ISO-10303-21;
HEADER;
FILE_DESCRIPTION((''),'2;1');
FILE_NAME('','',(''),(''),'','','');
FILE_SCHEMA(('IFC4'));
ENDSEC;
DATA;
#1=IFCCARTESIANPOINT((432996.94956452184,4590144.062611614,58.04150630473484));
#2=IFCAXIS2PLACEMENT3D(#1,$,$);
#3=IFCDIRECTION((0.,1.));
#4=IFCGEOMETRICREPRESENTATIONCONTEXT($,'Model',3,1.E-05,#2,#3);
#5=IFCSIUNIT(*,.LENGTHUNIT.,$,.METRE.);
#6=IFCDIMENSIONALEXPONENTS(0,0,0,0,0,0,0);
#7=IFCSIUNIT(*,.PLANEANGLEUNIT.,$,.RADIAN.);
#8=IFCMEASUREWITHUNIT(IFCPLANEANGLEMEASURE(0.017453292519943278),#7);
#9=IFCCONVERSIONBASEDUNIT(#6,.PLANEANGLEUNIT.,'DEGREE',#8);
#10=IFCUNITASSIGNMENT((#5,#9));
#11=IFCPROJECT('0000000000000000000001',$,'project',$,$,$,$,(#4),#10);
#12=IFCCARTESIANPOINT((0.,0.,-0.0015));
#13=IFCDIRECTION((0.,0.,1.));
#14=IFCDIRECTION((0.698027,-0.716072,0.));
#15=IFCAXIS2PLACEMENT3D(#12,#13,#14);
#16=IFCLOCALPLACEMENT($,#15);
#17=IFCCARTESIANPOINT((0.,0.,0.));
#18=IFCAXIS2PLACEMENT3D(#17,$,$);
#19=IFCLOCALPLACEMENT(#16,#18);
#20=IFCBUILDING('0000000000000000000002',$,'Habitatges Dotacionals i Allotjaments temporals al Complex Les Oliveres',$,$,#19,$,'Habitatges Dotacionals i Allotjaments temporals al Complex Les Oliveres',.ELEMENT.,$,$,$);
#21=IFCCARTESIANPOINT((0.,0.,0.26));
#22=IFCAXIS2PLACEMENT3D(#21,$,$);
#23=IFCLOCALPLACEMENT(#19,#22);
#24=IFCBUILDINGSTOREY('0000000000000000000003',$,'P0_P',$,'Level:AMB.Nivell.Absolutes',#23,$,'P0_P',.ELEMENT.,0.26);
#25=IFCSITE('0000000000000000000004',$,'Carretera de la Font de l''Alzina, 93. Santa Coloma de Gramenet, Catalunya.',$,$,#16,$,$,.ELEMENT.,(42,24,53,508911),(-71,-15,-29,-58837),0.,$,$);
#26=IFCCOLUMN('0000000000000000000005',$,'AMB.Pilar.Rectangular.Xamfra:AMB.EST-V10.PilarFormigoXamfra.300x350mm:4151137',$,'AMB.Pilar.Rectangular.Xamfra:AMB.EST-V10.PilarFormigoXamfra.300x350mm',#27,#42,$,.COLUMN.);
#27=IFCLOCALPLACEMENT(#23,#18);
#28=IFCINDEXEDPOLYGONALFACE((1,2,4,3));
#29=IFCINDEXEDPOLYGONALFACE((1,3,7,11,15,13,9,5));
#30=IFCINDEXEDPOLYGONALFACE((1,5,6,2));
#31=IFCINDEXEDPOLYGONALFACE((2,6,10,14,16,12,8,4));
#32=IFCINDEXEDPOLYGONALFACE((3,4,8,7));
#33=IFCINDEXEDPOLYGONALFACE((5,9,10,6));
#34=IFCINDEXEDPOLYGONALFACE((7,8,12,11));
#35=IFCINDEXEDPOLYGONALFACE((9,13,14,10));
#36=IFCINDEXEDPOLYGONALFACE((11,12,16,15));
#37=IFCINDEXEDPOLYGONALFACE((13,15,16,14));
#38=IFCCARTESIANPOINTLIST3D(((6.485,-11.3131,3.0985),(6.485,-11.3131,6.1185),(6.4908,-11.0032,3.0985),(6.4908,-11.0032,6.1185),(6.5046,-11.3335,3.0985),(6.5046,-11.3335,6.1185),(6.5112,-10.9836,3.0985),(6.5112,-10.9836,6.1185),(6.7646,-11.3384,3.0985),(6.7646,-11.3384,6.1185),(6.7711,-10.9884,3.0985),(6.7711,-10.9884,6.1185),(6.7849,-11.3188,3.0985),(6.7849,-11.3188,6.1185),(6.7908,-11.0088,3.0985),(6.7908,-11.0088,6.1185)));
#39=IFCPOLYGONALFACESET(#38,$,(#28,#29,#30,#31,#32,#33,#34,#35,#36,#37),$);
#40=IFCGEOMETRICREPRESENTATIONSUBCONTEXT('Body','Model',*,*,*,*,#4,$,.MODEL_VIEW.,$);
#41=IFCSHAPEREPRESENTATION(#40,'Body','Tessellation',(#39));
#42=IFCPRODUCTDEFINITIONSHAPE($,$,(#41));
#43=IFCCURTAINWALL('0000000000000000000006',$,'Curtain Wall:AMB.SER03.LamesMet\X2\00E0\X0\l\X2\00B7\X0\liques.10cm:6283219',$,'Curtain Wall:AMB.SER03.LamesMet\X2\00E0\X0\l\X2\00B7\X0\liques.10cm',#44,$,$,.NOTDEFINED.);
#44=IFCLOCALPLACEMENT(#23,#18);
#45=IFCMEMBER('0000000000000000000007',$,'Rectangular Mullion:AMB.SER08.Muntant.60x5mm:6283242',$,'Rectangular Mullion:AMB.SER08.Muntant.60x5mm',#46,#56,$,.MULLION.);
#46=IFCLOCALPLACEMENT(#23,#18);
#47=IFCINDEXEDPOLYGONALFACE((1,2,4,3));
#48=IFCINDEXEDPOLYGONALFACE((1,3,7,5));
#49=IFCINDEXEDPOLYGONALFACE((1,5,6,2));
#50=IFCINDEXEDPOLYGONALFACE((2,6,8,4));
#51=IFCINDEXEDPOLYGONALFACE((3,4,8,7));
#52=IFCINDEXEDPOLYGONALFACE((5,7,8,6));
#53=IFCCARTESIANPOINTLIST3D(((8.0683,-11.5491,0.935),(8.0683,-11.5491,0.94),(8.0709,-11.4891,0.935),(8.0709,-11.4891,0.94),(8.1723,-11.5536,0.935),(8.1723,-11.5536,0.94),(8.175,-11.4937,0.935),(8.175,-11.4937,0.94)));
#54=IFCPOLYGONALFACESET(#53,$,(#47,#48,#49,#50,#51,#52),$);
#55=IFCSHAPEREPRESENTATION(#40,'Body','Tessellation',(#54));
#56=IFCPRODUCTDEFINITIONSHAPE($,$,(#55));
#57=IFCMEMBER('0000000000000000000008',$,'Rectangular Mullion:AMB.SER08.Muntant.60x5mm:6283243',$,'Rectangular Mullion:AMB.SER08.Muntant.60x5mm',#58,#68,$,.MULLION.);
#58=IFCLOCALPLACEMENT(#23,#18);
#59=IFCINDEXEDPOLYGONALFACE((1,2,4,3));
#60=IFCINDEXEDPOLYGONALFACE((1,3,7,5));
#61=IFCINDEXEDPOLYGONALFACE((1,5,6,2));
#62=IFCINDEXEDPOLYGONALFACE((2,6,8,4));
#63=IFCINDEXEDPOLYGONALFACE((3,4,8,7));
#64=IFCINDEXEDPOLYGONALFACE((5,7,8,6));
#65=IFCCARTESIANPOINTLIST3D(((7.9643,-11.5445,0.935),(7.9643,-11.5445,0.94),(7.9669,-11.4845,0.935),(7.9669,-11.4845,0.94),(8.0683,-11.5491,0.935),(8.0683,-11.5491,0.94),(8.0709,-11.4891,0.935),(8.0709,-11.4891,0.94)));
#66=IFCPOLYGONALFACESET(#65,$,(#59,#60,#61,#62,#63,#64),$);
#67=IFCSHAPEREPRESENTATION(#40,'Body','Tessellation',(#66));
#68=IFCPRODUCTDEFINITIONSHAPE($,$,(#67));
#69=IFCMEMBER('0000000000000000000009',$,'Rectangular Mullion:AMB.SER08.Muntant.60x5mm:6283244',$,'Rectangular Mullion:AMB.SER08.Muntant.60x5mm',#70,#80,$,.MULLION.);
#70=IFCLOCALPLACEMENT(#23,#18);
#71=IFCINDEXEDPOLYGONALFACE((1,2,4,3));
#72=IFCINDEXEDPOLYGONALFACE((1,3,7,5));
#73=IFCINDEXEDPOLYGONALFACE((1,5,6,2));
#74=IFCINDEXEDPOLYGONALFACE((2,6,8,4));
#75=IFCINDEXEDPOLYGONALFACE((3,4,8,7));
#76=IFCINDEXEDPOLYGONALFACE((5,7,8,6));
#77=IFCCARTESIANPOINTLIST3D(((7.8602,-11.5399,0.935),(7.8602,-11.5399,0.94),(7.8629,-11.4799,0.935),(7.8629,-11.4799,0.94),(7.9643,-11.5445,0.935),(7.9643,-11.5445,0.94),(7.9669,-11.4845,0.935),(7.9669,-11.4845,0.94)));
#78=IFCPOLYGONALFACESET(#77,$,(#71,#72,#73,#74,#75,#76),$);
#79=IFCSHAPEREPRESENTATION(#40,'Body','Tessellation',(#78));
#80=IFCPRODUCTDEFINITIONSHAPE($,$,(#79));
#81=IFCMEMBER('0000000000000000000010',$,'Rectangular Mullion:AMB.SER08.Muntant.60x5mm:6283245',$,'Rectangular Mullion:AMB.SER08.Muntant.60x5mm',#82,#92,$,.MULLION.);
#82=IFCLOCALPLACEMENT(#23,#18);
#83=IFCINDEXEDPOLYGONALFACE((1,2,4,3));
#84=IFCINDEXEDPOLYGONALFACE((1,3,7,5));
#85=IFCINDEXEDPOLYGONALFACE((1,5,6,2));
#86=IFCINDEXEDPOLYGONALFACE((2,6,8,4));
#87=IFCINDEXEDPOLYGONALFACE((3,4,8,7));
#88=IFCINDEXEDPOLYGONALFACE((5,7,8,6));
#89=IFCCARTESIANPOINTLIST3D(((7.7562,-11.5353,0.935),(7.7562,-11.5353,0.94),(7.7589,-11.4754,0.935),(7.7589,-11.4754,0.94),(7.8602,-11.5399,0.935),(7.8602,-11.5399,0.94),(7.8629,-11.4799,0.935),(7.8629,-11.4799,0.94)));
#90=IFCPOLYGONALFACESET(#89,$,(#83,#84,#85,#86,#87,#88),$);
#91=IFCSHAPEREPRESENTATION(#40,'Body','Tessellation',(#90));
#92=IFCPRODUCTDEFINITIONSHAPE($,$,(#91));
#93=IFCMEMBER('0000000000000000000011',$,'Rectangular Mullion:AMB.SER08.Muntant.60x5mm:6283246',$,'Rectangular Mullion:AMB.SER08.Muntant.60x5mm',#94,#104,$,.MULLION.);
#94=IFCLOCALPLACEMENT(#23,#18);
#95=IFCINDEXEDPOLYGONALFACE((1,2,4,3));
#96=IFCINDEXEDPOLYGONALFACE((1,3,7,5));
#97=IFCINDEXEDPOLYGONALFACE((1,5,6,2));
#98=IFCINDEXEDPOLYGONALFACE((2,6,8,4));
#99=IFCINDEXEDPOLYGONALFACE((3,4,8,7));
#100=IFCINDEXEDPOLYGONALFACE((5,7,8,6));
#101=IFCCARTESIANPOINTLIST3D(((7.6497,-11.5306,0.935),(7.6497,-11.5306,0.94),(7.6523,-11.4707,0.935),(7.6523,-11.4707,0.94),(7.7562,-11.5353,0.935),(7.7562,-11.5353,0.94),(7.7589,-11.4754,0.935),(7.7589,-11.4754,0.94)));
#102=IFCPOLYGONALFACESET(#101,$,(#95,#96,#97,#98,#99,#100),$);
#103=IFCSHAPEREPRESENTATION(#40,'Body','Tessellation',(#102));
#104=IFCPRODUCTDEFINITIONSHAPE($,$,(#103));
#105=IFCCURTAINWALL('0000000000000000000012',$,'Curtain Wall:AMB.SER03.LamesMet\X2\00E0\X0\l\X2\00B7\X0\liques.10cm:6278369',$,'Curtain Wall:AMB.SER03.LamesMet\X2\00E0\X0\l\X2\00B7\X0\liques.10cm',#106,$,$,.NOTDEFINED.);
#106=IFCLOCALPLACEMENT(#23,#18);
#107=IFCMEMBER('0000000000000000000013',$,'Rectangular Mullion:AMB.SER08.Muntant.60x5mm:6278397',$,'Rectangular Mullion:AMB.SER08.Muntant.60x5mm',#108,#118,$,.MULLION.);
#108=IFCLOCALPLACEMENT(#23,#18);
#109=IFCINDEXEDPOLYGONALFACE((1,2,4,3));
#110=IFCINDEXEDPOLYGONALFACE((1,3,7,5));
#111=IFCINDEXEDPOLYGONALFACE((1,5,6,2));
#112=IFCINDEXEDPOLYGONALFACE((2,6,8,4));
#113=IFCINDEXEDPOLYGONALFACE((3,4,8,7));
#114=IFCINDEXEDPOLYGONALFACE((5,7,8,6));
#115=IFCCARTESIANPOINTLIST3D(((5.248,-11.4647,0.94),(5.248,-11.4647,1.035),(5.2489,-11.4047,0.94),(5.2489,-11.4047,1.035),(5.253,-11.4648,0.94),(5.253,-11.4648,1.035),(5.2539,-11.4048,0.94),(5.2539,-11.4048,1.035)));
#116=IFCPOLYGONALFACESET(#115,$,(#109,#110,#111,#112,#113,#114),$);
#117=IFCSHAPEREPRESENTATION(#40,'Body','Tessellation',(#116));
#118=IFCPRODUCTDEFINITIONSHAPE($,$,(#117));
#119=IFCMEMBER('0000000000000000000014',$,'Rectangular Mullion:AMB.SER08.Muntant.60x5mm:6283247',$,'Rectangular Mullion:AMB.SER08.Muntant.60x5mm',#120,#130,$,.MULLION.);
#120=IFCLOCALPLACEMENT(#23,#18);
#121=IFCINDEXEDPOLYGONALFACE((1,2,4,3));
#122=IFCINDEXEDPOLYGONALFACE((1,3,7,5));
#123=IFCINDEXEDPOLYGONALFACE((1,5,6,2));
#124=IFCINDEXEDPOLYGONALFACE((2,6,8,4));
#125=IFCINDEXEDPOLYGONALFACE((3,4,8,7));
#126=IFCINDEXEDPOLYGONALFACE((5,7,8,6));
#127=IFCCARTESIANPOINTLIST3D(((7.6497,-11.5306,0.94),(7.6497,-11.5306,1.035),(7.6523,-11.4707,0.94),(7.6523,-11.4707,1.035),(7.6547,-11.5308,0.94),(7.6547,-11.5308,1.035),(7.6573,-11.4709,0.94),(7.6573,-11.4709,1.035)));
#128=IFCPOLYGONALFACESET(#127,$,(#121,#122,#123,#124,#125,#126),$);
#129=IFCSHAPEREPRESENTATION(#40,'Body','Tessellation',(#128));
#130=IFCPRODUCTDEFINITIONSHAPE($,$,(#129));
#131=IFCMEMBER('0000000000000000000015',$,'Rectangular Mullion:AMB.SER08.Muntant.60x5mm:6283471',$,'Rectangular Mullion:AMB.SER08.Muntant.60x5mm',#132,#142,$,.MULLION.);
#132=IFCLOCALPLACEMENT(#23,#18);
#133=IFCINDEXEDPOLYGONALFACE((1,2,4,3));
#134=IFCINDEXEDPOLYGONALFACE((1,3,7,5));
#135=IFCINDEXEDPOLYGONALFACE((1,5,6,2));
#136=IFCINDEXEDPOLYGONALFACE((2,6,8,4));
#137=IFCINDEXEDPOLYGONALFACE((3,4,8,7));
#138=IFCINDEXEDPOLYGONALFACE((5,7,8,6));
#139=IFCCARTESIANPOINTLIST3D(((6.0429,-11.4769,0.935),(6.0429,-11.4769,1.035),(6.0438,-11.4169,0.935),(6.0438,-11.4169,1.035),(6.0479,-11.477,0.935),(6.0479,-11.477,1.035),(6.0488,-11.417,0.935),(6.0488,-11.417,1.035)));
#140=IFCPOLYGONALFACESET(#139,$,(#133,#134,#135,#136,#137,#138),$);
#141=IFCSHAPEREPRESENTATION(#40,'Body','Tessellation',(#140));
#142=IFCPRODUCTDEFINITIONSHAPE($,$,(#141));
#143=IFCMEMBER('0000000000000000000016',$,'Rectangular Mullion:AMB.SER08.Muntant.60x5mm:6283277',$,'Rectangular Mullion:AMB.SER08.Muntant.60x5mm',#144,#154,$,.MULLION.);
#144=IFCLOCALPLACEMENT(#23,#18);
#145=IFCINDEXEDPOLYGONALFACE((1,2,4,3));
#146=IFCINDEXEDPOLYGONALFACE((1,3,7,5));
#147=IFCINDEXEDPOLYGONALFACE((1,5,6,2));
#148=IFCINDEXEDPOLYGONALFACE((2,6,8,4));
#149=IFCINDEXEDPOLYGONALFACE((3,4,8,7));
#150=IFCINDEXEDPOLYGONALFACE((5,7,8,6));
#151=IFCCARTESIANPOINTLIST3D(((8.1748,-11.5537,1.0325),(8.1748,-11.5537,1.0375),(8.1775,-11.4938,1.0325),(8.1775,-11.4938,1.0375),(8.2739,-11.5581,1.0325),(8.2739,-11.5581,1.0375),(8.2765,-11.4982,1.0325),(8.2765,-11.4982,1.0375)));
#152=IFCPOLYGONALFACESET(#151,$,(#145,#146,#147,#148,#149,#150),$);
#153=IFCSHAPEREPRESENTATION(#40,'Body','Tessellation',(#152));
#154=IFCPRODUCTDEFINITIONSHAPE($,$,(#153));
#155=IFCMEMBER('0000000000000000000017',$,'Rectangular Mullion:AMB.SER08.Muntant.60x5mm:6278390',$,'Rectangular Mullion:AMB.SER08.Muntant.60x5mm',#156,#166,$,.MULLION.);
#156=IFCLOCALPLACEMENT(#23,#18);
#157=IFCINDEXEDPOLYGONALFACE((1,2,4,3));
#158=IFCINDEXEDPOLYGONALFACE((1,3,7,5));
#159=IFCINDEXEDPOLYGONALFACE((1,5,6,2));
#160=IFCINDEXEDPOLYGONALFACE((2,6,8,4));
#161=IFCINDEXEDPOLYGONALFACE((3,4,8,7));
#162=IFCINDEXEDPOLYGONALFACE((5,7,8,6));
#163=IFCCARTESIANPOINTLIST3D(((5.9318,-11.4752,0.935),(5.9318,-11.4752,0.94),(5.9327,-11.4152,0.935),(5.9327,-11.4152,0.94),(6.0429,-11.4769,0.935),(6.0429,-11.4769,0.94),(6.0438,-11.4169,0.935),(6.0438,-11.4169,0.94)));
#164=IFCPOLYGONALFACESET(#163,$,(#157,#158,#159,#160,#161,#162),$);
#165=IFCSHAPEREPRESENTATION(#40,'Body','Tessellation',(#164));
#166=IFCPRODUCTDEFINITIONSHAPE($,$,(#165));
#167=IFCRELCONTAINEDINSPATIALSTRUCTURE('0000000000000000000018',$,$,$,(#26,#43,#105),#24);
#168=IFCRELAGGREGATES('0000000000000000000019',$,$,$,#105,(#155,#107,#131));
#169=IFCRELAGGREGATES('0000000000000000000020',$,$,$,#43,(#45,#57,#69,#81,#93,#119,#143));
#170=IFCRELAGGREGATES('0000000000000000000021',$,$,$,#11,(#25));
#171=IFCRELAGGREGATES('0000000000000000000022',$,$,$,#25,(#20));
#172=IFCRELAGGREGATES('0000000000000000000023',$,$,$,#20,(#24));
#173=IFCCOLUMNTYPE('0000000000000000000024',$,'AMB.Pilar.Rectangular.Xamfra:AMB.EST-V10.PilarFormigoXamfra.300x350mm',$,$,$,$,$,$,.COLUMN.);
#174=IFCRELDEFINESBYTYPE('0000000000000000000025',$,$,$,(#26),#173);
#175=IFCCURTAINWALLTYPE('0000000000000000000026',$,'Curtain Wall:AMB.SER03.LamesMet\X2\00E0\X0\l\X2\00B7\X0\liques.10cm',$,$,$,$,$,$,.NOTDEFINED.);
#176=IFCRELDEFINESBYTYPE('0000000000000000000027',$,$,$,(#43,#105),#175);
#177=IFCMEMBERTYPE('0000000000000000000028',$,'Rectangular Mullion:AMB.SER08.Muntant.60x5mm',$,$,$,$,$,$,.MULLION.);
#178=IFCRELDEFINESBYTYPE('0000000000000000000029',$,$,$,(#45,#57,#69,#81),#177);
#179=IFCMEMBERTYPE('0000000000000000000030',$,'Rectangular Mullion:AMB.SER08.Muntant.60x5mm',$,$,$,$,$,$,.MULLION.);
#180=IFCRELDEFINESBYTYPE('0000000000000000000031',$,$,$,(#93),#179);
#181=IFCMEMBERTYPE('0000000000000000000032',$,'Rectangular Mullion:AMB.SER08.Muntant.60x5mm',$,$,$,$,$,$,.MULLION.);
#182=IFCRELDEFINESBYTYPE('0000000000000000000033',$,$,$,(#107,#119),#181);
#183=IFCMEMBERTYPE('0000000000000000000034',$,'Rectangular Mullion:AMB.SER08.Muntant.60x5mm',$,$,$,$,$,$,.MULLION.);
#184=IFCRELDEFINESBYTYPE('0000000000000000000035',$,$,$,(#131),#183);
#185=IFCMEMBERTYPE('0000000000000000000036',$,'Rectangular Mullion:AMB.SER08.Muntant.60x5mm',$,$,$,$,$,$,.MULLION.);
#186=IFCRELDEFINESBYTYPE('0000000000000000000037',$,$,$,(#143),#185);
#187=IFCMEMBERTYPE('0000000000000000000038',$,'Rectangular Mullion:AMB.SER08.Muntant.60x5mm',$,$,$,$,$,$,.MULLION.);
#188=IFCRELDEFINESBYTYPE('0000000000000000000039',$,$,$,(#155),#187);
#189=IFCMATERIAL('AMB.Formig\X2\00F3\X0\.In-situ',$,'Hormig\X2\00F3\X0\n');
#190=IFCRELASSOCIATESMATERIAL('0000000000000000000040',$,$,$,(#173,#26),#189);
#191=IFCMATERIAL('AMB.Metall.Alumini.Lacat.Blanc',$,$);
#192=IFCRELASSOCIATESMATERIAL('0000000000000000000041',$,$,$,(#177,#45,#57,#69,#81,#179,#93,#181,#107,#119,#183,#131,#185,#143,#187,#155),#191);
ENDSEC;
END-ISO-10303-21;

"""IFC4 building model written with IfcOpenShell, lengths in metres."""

from ifc_helpers import new_model, entity, si_unit, converted_unit, direction, frame, origin, place, context, subcontext, project, spatial, indexed_curve, outline, extrude, source, transform, mapped, material, type_object, type_shapes, element, aggregate, save


model = new_model("IFC4")

# Units and contexts
model_context = context("Model", 3, precision=1e-05, world=frame((432996.94956452184, 4590144.062611614, 58.04150630473484)), true_north=direction((0.0, 1.0)))
body_context = subcontext(model_context, "Body", "Model", "MODEL_VIEW")
ifc_project = project(units=[si_unit("LENGTHUNIT", "METRE"), converted_unit("PLANEANGLEUNIT", "DEGREE", entity("IfcPlaneAngleMeasure", 0.017453292519943278), si_unit("PLANEANGLEUNIT", "RADIAN"), dimensions=[0, 0, 0, 0, 0, 0, 0])], contexts=[model_context])

# Site, building, storey
site_placement = place(None, frame((0.0, 0.0, -0.0015), z_axis=(0.0, 0.0, 1.0), x_axis=(0.698027, -0.716072, 0.0)))
site = spatial("IfcSite", under=ifc_project, at=site_placement, Name="Carretera de la Font de l'Alzina, 93. Santa Coloma de Gramenet, Catalunya.", CompositionType="ELEMENT", RefLatitude=(42, 24, 53, 508911), RefLongitude=(-71, -15, -29, -58837), RefElevation=0.0)
building_placement = place(site_placement, origin())
building = spatial("IfcBuilding", under=site, at=building_placement, Name="Habitatges Dotacionals i Allotjaments temporals al Complex Les Oliveres", LongName="Habitatges Dotacionals i Allotjaments temporals al Complex Les Oliveres", CompositionType="ELEMENT")
storey_placement = place(building_placement, frame((0.0, 0.0, 0.26)))
storey = spatial("IfcBuildingStorey", under=building, at=storey_placement, Name="P0_P", ObjectType="Level:AMB.Nivell.Absolutes", LongName="P0_P", CompositionType="ELEMENT", Elevation=0.26)

# Column
ifc_material_1 = material(Name="AMB.Formigó.In-situ", Category="Hormigón")
column_type = type_object("IfcColumnType", Name="AMB.Pilar.Rectangular.Xamfra:AMB.EST-V10.PilarFormigoXamfra.300x350mm", PredefinedType="COLUMN", material=ifc_material_1)
shared_shape_1 = source(origin(), body_context, "Body", "SweptSolid", [
    extrude(outline(indexed_curve([(-0.13, -0.175), (0.13, -0.175), (0.15, -0.155), (0.15, 0.155), (0.13, 0.175), (-0.13, 0.175), (-0.15, 0.155), (-0.15, -0.155), (-0.13, -0.175)], self_intersect=False)), frame((0.0, 0.0, 3.3585), z_axis=(0.0, 0.0, 1.0), x_axis=(-1.0, 0.0, 0.0)), (0.0, 0.0, 1.0), 3.02),
])
type_shapes(column_type, [shared_shape_1])
column_placement = place(storey_placement, frame((6.6379, -11.161, -0.26), z_axis=(0.0, 0.0, 1.0), x_axis=(0.999823, -0.018804, 0.0)))
element("IfcColumn", 1, at=column_placement, inside=storey, type_object=column_type, material=ifc_material_1, Name="AMB.Pilar.Rectangular.Xamfra:AMB.EST-V10.PilarFormigoXamfra.300x350mm:4151137", ObjectType="AMB.Pilar.Rectangular.Xamfra:AMB.EST-V10.PilarFormigoXamfra.300x350mm", PredefinedType="COLUMN", context=body_context, shape_type="MappedRepresentation", body=[
    mapped(shared_shape_1, transform((0.0, 0.0, 0.0), scale=1.0)),
])

# Curtain wall, members
curtain_wall_type = type_object("IfcCurtainWallType", Name="Curtain Wall:AMB.SER03.LamesMetàl·liques.10cm", PredefinedType="NOTDEFINED")
curtain_wall_1_placement = place(storey_placement, frame((0.0, 0.0, -0.26)))
curtain_wall_1 = element("IfcCurtainWall", 2, at=curtain_wall_1_placement, inside=storey, type_object=curtain_wall_type, Name="Curtain Wall:AMB.SER03.LamesMetàl·liques.10cm:6283219", ObjectType="Curtain Wall:AMB.SER03.LamesMetàl·liques.10cm", PredefinedType="NOTDEFINED")
ifc_material_2 = material(Name="AMB.Metall.Alumini.Lacat.Blanc")
member_type_1 = type_object("IfcMemberType", Name="Rectangular Mullion:AMB.SER08.Muntant.60x5mm", PredefinedType="MULLION", material=ifc_material_2)
shared_shape_2 = source(origin(), body_context, "Body", "SweptSolid", [
    extrude(outline(indexed_curve([(-0.0025, -0.03), (0.0025, -0.03), (0.0025, 0.03), (-0.0025, 0.03), (-0.0025, -0.03)], self_intersect=False)), frame((-0.0025, 0.03, -0.1041), z_axis=(0.0, 0.0, 1.0), x_axis=(-1.0, 0.0, 0.0)), (0.0, 0.0, 1.0), 0.1041),
])
type_shapes(member_type_1, [shared_shape_2])
member_1_placement = place(curtain_wall_1_placement, frame((8.1723, -11.5536, 1.195), z_axis=(0.99903, -0.044031, 0.0), x_axis=(0.0, 0.0, -1.0)))
member_1 = element("IfcMember", 3, at=member_1_placement, type_object=member_type_1, material=ifc_material_2, Name="Rectangular Mullion:AMB.SER08.Muntant.60x5mm:6283242", ObjectType="Rectangular Mullion:AMB.SER08.Muntant.60x5mm", PredefinedType="MULLION", context=body_context, shape_type="MappedRepresentation", body=[
    mapped(shared_shape_2, transform((0.0, 0.0, 0.0), scale=1.0)),
])
member_2_placement = place(curtain_wall_1_placement, frame((8.0683, -11.5491, 1.195), z_axis=(0.99903, -0.044031, 0.0), x_axis=(0.0, 0.0, -1.0)))
member_2 = element("IfcMember", 4, at=member_2_placement, type_object=member_type_1, material=ifc_material_2, Name="Rectangular Mullion:AMB.SER08.Muntant.60x5mm:6283243", ObjectType="Rectangular Mullion:AMB.SER08.Muntant.60x5mm", PredefinedType="MULLION", context=body_context, shape_type="MappedRepresentation", body=[
    mapped(shared_shape_2, transform((0.0, 0.0, 0.0), scale=1.0)),
])
member_3_placement = place(curtain_wall_1_placement, frame((7.9643, -11.5445, 1.195), z_axis=(0.99903, -0.044031, 0.0), x_axis=(0.0, 0.0, -1.0)))
member_3 = element("IfcMember", 5, at=member_3_placement, type_object=member_type_1, material=ifc_material_2, Name="Rectangular Mullion:AMB.SER08.Muntant.60x5mm:6283244", ObjectType="Rectangular Mullion:AMB.SER08.Muntant.60x5mm", PredefinedType="MULLION", context=body_context, shape_type="MappedRepresentation", body=[
    mapped(shared_shape_2, transform((0.0, 0.0, 0.0), scale=1.0)),
])
member_4_placement = place(curtain_wall_1_placement, frame((7.8602, -11.5399, 1.195), z_axis=(0.99903, -0.044031, 0.0), x_axis=(0.0, 0.0, -1.0)))
member_4 = element("IfcMember", 6, at=member_4_placement, type_object=member_type_1, material=ifc_material_2, Name="Rectangular Mullion:AMB.SER08.Muntant.60x5mm:6283245", ObjectType="Rectangular Mullion:AMB.SER08.Muntant.60x5mm", PredefinedType="MULLION", context=body_context, shape_type="MappedRepresentation", body=[
    mapped(shared_shape_2, transform((0.0, 0.0, 0.0), scale=1.0)),
])
member_type_2 = type_object("IfcMemberType", Name="Rectangular Mullion:AMB.SER08.Muntant.60x5mm", PredefinedType="MULLION", material=ifc_material_2)
shared_shape_3 = source(origin(), body_context, "Body", "SweptSolid", [
    extrude(outline(indexed_curve([(-0.0025, -0.03), (0.0025, -0.03), (0.0025, 0.03), (-0.0025, 0.03), (-0.0025, -0.03)], self_intersect=False)), frame((-0.0025, 0.03, -0.1066), z_axis=(0.0, 0.0, 1.0), x_axis=(-1.0, 0.0, 0.0)), (0.0, 0.0, 1.0), 0.1066),
])
type_shapes(member_type_2, [shared_shape_3])
member_5_placement = place(curtain_wall_1_placement, frame((7.7562, -11.5353, 1.195), z_axis=(0.99903, -0.044031, 0.0), x_axis=(0.0, 0.0, -1.0)))
member_5 = element("IfcMember", 7, at=member_5_placement, type_object=member_type_2, material=ifc_material_2, Name="Rectangular Mullion:AMB.SER08.Muntant.60x5mm:6283246", ObjectType="Rectangular Mullion:AMB.SER08.Muntant.60x5mm", PredefinedType="MULLION", context=body_context, shape_type="MappedRepresentation", body=[
    mapped(shared_shape_3, transform((0.0, 0.0, 0.0), scale=1.0)),
])

# Curtain wall, member
curtain_wall_2_placement = place(storey_placement, frame((0.0, 0.0, -0.26)))
curtain_wall_2 = element("IfcCurtainWall", 8, at=curtain_wall_2_placement, inside=storey, type_object=curtain_wall_type, Name="Curtain Wall:AMB.SER03.LamesMetàl·liques.10cm:6278369", ObjectType="Curtain Wall:AMB.SER03.LamesMetàl·liques.10cm", PredefinedType="NOTDEFINED")
member_type_3 = type_object("IfcMemberType", Name="Rectangular Mullion:AMB.SER08.Muntant.60x5mm", PredefinedType="MULLION", material=ifc_material_2)
shared_shape_4 = source(origin(), body_context, "Body", "SweptSolid", [
    extrude(outline(indexed_curve([(-0.0025, -0.03), (0.0025, -0.03), (0.0025, 0.03), (-0.0025, 0.03), (-0.0025, -0.03)], self_intersect=False)), frame((-0.0025, 0.03, -0.095), z_axis=(0.0, 0.0, 1.0), x_axis=(-1.0, 0.0, 0.0)), (0.0, 0.0, 1.0), 0.095),
])
type_shapes(member_type_3, [shared_shape_4])
member_6_placement = place(curtain_wall_2_placement, frame((5.248, -11.4647, 1.2), z_axis=(0.0, 0.0, -1.0), x_axis=(-0.999883, 0.015319, 0.0)))
member_6 = element("IfcMember", 9, at=member_6_placement, type_object=member_type_3, material=ifc_material_2, Name="Rectangular Mullion:AMB.SER08.Muntant.60x5mm:6278397", ObjectType="Rectangular Mullion:AMB.SER08.Muntant.60x5mm", PredefinedType="MULLION", context=body_context, shape_type="MappedRepresentation", body=[
    mapped(shared_shape_4, transform((0.0, 0.0, 0.0), scale=1.0)),
])

# Members
member_7_placement = place(curtain_wall_1_placement, frame((7.6497, -11.5306, 1.2), z_axis=(0.0, 0.0, -1.0), x_axis=(-0.99903, 0.044031, 0.0)))
member_7 = element("IfcMember", 10, at=member_7_placement, type_object=member_type_3, material=ifc_material_2, Name="Rectangular Mullion:AMB.SER08.Muntant.60x5mm:6283247", ObjectType="Rectangular Mullion:AMB.SER08.Muntant.60x5mm", PredefinedType="MULLION", context=body_context, shape_type="MappedRepresentation", body=[
    mapped(shared_shape_4, transform((0.0, 0.0, 0.0), scale=1.0)),
])
member_type_4 = type_object("IfcMemberType", Name="Rectangular Mullion:AMB.SER08.Muntant.60x5mm", PredefinedType="MULLION", material=ifc_material_2)
shared_shape_5 = source(origin(), body_context, "Body", "SweptSolid", [
    extrude(outline(indexed_curve([(-0.0025, -0.03), (0.0025, -0.03), (0.0025, 0.03), (-0.0025, 0.03), (-0.0025, -0.03)], self_intersect=False)), frame((-0.0025, 0.03, -0.1), z_axis=(0.0, 0.0, 1.0), x_axis=(-1.0, 0.0, 0.0)), (0.0, 0.0, 1.0), 0.1),
])
type_shapes(member_type_4, [shared_shape_5])
member_8_placement = place(curtain_wall_2_placement, frame((6.0479, -11.477, 1.295), z_axis=(0.0, 0.0, 1.0), x_axis=(0.999883, -0.015319, 0.0)))
member_8 = element("IfcMember", 11, at=member_8_placement, type_object=member_type_4, material=ifc_material_2, Name="Rectangular Mullion:AMB.SER08.Muntant.60x5mm:6283471", ObjectType="Rectangular Mullion:AMB.SER08.Muntant.60x5mm", PredefinedType="MULLION", context=body_context, shape_type="MappedRepresentation", body=[
    mapped(shared_shape_5, transform((0.0, 0.0, 0.0), scale=1.0)),
])
member_type_5 = type_object("IfcMemberType", Name="Rectangular Mullion:AMB.SER08.Muntant.60x5mm", PredefinedType="MULLION", material=ifc_material_2)
shared_shape_6 = source(origin(), body_context, "Body", "SweptSolid", [
    extrude(outline(indexed_curve([(-0.0025, -0.03), (0.0025, -0.03), (0.0025, 0.03), (-0.0025, 0.03), (-0.0025, -0.03)], self_intersect=False)), frame((0.0, 0.03, -0.0991), z_axis=(0.0, 0.0, 1.0), x_axis=(-1.0, 0.0, 0.0)), (0.0, 0.0, 1.0), 0.0991),
])
type_shapes(member_type_5, [shared_shape_6])
member_9_placement = place(curtain_wall_1_placement, frame((8.1748, -11.5537, 1.295), z_axis=(-0.99903, 0.044031, 0.0), x_axis=(0.0, 0.0, 1.0)))
member_9 = element("IfcMember", 12, at=member_9_placement, type_object=member_type_5, material=ifc_material_2, Name="Rectangular Mullion:AMB.SER08.Muntant.60x5mm:6283277", ObjectType="Rectangular Mullion:AMB.SER08.Muntant.60x5mm", PredefinedType="MULLION", context=body_context, shape_type="MappedRepresentation", body=[
    mapped(shared_shape_6, transform((0.0, 0.0, 0.0), scale=1.0)),
])
member_type_6 = type_object("IfcMemberType", Name="Rectangular Mullion:AMB.SER08.Muntant.60x5mm", PredefinedType="MULLION", material=ifc_material_2)
shared_shape_7 = source(origin(), body_context, "Body", "SweptSolid", [
    extrude(outline(indexed_curve([(-0.0025, -0.03), (0.0025, -0.03), (0.0025, 0.03), (-0.0025, 0.03), (-0.0025, -0.03)], self_intersect=False)), frame((-0.0025, 0.03, -0.1111), z_axis=(0.0, 0.0, 1.0), x_axis=(-1.0, 0.0, 0.0)), (0.0, 0.0, 1.0), 0.1111),
])
type_shapes(member_type_6, [shared_shape_7])
member_10_placement = place(curtain_wall_2_placement, frame((6.0429, -11.4769, 1.195), z_axis=(0.999883, -0.015319, 0.0), x_axis=(0.0, 0.0, -1.0)))
member_10 = element("IfcMember", 13, at=member_10_placement, type_object=member_type_6, material=ifc_material_2, Name="Rectangular Mullion:AMB.SER08.Muntant.60x5mm:6278390", ObjectType="Rectangular Mullion:AMB.SER08.Muntant.60x5mm", PredefinedType="MULLION", context=body_context, shape_type="MappedRepresentation", body=[
    mapped(shared_shape_7, transform((0.0, 0.0, 0.0), scale=1.0)),
])
aggregate(curtain_wall_2, [member_10, member_6, member_8])
aggregate(curtain_wall_1, [member_1, member_2, member_3, member_4, member_5, member_7, member_9])

save(model, "model.ifc")
